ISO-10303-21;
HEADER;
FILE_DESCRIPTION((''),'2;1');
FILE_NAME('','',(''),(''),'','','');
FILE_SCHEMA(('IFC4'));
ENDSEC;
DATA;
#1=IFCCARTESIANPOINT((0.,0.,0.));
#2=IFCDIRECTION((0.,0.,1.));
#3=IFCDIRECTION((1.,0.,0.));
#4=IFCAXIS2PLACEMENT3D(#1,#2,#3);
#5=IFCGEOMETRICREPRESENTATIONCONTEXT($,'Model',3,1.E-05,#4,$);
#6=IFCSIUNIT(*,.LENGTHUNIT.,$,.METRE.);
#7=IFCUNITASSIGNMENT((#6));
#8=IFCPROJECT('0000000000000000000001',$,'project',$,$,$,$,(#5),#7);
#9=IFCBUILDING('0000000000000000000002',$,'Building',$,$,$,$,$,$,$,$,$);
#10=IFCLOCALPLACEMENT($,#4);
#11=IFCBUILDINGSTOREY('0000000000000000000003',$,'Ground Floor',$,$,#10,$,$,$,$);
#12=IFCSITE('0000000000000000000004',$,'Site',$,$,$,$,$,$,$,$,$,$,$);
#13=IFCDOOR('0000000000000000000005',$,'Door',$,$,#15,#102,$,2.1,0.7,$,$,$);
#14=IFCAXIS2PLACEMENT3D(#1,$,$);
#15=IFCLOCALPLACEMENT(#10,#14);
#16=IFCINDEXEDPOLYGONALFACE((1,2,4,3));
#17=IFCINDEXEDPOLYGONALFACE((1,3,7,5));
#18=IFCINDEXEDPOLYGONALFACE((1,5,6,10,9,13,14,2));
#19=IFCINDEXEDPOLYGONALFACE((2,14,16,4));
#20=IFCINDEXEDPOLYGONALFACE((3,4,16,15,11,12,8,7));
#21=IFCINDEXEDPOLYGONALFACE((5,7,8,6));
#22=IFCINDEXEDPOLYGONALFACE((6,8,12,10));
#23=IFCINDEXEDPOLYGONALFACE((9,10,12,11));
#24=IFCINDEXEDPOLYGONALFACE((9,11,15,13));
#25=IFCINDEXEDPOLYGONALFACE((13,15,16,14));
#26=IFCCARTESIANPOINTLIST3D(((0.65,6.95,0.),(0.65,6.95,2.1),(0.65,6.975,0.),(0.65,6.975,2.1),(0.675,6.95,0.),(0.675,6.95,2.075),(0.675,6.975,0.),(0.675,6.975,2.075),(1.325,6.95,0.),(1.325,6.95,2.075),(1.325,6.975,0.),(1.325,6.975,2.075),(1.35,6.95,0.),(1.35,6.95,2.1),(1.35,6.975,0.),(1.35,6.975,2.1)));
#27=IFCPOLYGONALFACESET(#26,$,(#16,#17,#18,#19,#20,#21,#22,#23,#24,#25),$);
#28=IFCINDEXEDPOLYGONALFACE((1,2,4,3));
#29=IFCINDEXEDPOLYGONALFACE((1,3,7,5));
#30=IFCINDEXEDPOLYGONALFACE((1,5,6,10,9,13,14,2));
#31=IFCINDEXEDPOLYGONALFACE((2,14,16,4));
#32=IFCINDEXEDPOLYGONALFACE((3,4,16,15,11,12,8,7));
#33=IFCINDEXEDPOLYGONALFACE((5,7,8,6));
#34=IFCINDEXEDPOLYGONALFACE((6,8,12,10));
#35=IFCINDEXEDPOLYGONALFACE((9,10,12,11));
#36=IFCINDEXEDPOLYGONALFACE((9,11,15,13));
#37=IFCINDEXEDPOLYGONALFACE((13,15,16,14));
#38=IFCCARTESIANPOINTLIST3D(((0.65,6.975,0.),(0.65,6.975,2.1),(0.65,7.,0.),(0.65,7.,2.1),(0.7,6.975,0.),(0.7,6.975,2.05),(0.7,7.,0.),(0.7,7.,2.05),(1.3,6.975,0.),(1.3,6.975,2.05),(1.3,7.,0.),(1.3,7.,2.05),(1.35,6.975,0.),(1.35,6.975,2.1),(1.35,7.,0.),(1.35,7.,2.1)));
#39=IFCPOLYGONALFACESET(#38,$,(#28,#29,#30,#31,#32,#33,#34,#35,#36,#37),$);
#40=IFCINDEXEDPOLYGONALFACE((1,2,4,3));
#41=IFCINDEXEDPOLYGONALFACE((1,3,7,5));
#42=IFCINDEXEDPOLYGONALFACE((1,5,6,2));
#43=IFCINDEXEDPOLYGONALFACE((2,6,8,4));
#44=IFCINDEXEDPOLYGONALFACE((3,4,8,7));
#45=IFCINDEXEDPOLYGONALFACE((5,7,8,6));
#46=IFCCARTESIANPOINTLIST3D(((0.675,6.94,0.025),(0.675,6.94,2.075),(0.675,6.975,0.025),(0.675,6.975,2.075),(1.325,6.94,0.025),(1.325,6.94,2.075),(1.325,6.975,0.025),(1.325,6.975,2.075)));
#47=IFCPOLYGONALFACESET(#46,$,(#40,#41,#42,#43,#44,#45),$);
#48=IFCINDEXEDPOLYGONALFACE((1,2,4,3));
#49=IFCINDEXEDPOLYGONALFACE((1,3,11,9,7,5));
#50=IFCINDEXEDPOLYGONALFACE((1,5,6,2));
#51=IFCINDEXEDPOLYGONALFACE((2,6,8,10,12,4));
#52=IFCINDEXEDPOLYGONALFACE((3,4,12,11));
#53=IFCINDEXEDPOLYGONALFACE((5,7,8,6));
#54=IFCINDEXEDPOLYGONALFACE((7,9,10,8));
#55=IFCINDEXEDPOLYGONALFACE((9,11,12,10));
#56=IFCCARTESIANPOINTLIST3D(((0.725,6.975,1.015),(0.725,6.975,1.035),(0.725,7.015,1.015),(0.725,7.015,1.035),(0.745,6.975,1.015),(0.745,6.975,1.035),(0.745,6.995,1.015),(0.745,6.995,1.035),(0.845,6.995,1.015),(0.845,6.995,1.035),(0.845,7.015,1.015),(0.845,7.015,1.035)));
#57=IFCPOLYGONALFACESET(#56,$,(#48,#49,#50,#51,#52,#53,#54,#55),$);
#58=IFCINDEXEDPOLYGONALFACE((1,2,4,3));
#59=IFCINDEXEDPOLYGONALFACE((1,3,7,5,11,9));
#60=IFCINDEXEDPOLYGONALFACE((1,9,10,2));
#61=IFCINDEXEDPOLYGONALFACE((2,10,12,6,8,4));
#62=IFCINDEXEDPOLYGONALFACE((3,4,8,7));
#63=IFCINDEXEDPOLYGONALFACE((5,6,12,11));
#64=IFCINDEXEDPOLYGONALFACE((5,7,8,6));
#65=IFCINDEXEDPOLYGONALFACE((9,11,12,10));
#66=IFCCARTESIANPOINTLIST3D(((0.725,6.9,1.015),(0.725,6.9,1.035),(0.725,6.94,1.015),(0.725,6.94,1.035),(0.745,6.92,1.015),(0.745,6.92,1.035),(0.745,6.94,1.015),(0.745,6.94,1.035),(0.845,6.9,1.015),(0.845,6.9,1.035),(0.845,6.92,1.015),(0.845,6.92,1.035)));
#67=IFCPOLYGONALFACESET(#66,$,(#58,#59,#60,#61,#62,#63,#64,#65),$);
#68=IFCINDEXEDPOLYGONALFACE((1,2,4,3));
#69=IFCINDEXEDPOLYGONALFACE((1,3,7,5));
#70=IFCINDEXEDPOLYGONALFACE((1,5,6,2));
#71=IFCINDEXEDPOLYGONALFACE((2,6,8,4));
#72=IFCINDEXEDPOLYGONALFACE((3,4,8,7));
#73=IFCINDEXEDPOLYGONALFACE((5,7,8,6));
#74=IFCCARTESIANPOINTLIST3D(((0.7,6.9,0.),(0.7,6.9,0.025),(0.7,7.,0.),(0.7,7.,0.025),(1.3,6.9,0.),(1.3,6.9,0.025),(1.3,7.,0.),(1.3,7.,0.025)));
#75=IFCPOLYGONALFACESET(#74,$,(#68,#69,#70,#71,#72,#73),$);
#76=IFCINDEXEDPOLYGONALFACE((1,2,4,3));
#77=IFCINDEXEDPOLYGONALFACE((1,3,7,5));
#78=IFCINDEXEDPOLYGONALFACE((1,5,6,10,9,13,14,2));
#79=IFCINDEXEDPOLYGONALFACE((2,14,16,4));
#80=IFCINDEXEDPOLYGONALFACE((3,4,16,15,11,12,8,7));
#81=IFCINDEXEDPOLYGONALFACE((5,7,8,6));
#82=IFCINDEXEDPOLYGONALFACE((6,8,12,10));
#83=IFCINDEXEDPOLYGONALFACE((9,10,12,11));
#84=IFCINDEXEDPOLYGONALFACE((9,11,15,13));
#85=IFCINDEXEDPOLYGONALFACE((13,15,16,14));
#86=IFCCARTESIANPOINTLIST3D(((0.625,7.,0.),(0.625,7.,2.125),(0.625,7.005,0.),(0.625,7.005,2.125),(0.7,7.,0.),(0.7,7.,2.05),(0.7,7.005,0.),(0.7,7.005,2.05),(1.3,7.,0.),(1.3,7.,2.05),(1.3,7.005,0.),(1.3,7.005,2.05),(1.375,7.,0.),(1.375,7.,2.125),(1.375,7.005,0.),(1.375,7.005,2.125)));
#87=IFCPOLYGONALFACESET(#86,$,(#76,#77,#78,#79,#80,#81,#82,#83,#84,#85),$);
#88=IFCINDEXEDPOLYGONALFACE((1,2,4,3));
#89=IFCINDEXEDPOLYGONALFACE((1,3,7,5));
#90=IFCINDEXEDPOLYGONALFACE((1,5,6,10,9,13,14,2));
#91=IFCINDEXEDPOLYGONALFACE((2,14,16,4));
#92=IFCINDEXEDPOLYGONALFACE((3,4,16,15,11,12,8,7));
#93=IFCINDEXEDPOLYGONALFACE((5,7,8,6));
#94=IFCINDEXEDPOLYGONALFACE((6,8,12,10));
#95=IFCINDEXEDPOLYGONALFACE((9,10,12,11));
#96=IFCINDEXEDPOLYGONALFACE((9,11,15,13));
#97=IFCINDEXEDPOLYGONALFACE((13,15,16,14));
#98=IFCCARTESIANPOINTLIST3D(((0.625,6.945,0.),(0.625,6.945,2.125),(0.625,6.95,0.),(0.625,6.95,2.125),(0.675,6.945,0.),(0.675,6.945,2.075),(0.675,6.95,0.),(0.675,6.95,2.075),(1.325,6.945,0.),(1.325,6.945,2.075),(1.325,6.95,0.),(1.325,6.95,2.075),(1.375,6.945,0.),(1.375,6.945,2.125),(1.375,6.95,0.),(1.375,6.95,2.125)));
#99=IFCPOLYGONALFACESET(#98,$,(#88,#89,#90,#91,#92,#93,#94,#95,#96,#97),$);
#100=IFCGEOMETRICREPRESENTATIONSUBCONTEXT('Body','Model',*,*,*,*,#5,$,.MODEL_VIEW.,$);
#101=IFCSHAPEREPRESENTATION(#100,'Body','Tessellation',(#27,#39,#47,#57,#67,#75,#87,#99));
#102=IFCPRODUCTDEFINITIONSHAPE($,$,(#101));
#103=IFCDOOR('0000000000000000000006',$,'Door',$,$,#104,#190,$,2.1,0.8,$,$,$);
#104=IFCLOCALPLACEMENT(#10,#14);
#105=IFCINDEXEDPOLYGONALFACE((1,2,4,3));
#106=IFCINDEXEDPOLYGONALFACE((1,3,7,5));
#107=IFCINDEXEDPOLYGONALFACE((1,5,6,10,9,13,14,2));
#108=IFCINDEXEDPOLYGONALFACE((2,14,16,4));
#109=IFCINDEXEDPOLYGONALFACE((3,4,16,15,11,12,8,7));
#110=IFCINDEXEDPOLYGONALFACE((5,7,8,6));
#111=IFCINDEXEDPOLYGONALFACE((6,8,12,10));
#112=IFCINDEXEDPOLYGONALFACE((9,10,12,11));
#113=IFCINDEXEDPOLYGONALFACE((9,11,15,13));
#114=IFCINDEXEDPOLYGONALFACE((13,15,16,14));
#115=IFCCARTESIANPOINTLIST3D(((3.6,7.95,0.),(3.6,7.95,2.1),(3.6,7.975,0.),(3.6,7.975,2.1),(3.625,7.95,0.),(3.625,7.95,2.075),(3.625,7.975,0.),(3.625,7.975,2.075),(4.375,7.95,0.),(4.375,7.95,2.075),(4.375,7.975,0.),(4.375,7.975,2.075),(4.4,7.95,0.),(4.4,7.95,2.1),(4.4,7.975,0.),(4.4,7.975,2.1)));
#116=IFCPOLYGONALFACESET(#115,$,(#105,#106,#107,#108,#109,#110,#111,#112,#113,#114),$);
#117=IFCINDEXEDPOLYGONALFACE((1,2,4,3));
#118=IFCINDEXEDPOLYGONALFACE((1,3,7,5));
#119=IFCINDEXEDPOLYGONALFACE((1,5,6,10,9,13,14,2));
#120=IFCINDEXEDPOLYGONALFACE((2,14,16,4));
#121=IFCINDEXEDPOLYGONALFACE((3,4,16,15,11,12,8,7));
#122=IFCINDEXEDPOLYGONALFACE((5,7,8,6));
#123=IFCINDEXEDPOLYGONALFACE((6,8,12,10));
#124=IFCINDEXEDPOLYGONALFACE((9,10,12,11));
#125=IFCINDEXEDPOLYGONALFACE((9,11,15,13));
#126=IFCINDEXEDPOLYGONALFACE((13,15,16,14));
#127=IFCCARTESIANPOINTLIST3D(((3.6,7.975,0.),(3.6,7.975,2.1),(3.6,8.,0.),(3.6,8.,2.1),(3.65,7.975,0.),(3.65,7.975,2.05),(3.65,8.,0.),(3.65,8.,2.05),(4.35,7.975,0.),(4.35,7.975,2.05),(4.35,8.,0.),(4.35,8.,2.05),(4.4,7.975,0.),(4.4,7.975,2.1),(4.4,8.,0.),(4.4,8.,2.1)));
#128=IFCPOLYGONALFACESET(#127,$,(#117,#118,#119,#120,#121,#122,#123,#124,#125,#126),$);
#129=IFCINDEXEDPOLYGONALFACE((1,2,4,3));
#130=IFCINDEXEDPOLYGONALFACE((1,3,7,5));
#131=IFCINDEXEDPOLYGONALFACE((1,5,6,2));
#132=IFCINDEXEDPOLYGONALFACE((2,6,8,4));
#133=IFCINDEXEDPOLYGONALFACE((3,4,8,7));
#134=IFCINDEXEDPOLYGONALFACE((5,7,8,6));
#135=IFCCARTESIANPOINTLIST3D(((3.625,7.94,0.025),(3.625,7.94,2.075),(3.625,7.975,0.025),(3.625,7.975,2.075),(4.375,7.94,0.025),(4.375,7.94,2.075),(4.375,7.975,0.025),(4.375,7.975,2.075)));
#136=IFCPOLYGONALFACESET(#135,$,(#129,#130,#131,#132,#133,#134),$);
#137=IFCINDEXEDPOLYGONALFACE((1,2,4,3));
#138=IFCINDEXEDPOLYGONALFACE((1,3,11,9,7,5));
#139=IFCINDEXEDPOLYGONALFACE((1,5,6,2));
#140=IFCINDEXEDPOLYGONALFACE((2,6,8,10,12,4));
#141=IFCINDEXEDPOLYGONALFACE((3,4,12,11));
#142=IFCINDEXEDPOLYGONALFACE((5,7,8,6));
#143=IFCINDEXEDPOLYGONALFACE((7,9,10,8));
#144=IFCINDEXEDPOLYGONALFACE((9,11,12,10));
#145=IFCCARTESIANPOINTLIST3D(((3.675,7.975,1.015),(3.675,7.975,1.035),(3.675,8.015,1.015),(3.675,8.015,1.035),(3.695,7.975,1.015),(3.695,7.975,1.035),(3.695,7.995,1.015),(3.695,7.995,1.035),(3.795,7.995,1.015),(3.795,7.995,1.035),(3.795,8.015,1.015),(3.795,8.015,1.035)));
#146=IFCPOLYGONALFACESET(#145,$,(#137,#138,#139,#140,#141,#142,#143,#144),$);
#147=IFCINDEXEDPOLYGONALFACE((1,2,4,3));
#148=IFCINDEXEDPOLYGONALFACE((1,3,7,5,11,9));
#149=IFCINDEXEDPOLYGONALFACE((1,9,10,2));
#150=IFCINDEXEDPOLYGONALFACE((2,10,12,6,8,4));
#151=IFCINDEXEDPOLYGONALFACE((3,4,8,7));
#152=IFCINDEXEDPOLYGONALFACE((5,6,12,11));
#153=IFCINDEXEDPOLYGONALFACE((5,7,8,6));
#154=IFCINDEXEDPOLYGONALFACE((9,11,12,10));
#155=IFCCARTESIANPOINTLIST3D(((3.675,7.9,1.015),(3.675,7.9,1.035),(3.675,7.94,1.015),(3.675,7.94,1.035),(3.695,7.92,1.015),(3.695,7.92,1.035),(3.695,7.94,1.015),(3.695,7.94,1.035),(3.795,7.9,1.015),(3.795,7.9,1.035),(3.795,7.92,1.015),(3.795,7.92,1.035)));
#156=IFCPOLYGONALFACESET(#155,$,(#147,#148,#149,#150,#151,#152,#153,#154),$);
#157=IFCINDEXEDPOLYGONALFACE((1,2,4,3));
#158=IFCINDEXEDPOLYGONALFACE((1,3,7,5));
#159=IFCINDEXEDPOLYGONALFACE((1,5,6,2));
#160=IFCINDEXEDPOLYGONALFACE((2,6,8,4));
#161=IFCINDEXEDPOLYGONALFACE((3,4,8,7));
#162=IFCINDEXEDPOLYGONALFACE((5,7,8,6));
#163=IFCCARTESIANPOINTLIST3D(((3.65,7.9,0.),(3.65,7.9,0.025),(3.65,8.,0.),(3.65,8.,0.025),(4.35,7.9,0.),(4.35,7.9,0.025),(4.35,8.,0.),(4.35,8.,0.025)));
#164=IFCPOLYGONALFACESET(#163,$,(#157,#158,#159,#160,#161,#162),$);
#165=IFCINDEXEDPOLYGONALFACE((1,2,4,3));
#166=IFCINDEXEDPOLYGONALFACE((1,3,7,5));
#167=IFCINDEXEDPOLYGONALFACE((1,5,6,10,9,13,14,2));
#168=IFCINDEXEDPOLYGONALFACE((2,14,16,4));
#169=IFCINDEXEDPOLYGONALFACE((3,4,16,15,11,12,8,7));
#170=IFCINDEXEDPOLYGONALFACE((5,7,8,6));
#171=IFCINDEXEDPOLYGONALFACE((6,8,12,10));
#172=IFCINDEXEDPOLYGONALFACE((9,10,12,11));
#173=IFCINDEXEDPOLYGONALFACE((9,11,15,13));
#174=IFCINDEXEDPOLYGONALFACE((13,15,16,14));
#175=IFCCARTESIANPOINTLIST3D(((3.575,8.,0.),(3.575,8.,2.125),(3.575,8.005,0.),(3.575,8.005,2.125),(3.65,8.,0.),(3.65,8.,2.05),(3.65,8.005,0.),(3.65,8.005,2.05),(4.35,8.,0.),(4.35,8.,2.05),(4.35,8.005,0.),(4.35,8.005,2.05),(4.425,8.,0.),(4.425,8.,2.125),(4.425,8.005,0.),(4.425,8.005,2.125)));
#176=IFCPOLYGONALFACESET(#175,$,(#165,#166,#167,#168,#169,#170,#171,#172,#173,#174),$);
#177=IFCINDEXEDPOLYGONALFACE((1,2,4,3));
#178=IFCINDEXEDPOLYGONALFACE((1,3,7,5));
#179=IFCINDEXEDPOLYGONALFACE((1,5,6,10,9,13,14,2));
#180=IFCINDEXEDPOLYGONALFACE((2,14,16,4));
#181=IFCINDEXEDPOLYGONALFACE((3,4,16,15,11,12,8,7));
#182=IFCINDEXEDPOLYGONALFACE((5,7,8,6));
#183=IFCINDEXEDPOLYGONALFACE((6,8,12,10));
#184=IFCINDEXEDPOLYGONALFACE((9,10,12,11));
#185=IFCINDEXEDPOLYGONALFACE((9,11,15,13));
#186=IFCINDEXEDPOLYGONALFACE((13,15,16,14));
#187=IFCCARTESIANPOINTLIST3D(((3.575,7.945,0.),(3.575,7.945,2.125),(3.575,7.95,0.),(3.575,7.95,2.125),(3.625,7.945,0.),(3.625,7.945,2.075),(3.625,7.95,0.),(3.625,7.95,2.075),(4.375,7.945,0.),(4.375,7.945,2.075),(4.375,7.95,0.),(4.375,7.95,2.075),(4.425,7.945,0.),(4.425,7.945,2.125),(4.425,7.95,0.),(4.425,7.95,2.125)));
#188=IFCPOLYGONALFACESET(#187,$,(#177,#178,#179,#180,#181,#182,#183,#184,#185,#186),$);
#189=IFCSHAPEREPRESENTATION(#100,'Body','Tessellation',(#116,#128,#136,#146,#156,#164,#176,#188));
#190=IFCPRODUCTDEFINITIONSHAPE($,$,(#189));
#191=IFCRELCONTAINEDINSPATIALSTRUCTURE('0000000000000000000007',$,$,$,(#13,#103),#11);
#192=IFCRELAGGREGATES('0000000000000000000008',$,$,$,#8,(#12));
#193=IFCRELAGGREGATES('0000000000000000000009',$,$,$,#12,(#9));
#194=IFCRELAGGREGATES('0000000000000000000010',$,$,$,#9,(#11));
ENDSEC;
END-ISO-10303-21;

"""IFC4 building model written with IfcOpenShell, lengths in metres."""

from ifc_helpers import new_model, si_unit, frame, origin_with_axes, place, context, subcontext, project, spatial, line, indexed_curve, outline, extrude, element, save


model = new_model("IFC4")

# Units and contexts
model_context = context("Model", 3, precision=1e-05, world=origin_with_axes())
body_context = subcontext(model_context, "Body", "Model", "MODEL_VIEW")
ifc_project = project(units=[si_unit("LENGTHUNIT", "METRE")], contexts=[model_context])

# Site, building, storey
site = spatial("IfcSite", under=ifc_project, Name="Site")
building = spatial("IfcBuilding", under=site, Name="Building")
storey_placement = place(None, origin_with_axes())
storey = spatial("IfcBuildingStorey", under=building, at=storey_placement, Name="Ground Floor")

# Doors
door_1_placement = place(storey_placement, frame((1.35, 7.0, 0.0), z_axis=(0.0, 0.0, 1.0), x_axis=(-1.0, 0.0, 0.0)))
element("IfcDoor", 1, at=door_1_placement, inside=storey, Name="Door", OverallHeight=2.1, OverallWidth=0.7, context=body_context, shape_type="SweptSolid", body=[
    extrude(outline(indexed_curve([(0.0, 0.0), (0.0, 2.1), (0.7, 2.1), (0.7, 0.0), (0.675, 0.0), (0.675, 2.075), (0.025, 2.075), (0.025, 0.0)], segments=[line(1, 2, 3, 4, 5, 6, 7, 8, 1)])), frame((0.0, 0.025, 0.0), z_axis=(0.0, -1.0, 0.0), x_axis=(1.0, 0.0, 0.0)), (0.0, 0.0, -1.0), 0.025),
    extrude(outline(indexed_curve([(0.0, 0.0), (0.0, 2.1), (0.7, 2.1), (0.7, 0.0), (0.65, 0.0), (0.65, 2.05), (0.05, 2.05), (0.05, 0.0)], segments=[line(1, 2, 3, 4, 5, 6, 7, 8, 1)])), frame((0.0, 0.0, 0.0), z_axis=(0.0, -1.0, 0.0), x_axis=(1.0, 0.0, 0.0)), (0.0, 0.0, -1.0), 0.025),
    extrude(outline(indexed_curve([(0.0, 0.0), (0.65, 0.0), (0.65, 0.035), (0.0, 0.035)], segments=[line(1, 2, 3, 4, 1)])), frame((0.025, 0.025, 0.025), z_axis=(0.0, 0.0, 1.0), x_axis=(1.0, 0.0, 0.0)), (0.0, 0.0, 1.0), 2.05),
    extrude(outline(indexed_curve([(0.0, 0.0), (0.0, -0.04), (-0.12, -0.04), (-0.12, -0.02), (-0.02, -0.02), (-0.02, 0.0)], segments=[line(1, 2, 3, 4, 5, 6, 1)])), frame((0.625, 0.025, 1.015), z_axis=(0.0, 0.0, 1.0), x_axis=(1.0, 0.0, 0.0)), (0.0, 0.0, 1.0), 0.02),
    extrude(outline(indexed_curve([(0.0, 0.0), (0.0, 0.04), (-0.12, 0.04), (-0.12, 0.02), (-0.02, 0.02), (-0.02, 0.0)], segments=[line(1, 2, 3, 4, 5, 6, 1)])), frame((0.625, 0.06, 1.015), z_axis=(0.0, 0.0, 1.0), x_axis=(1.0, 0.0, 0.0)), (0.0, 0.0, 1.0), 0.02),
    extrude(outline(indexed_curve([(0.0, 0.0), (0.6, 0.0), (0.6, 0.1), (0.0, 0.1)], segments=[line(1, 2, 3, 4, 1)])), frame((0.05, 0.0, 0.0), z_axis=(0.0, 0.0, 1.0), x_axis=(1.0, 0.0, 0.0)), (0.0, 0.0, 1.0), 0.025),
    extrude(outline(indexed_curve([(0.0, 0.0), (0.0, 2.125), (0.75, 2.125), (0.75, 0.0), (0.675, 0.0), (0.675, 2.05), (0.075, 2.05), (0.075, 0.0)], segments=[line(1, 2, 3, 4, 5, 6, 7, 8, 1)])), frame((-0.025, -0.005, 0.0), z_axis=(0.0, -1.0, 0.0), x_axis=(1.0, 0.0, 0.0)), (0.0, 0.0, -1.0), 0.005),
    extrude(outline(indexed_curve([(0.0, 0.0), (0.0, 2.125), (0.75, 2.125), (0.75, 0.0), (0.7, 0.0), (0.7, 2.075), (0.05, 2.075), (0.05, 0.0)], segments=[line(1, 2, 3, 4, 5, 6, 7, 8, 1)])), frame((-0.025, 0.05, 0.0), z_axis=(0.0, -1.0, 0.0), x_axis=(1.0, 0.0, 0.0)), (0.0, 0.0, -1.0), 0.005),
])
door_2_placement = place(storey_placement, frame((4.4, 8.0, 0.0), z_axis=(0.0, 0.0, 1.0), x_axis=(-1.0, 0.0, 0.0)))
element("IfcDoor", 2, at=door_2_placement, inside=storey, Name="Door", OverallHeight=2.1, OverallWidth=0.8, context=body_context, shape_type="SweptSolid", body=[
    extrude(outline(indexed_curve([(0.0, 0.0), (0.0, 2.1), (0.8, 2.1), (0.8, 0.0), (0.775, 0.0), (0.775, 2.075), (0.025, 2.075), (0.025, 0.0)], segments=[line(1, 2, 3, 4, 5, 6, 7, 8, 1)])), frame((0.0, 0.025, 0.0), z_axis=(0.0, -1.0, 0.0), x_axis=(1.0, 0.0, 0.0)), (0.0, 0.0, -1.0), 0.025),
    extrude(outline(indexed_curve([(0.0, 0.0), (0.0, 2.1), (0.8, 2.1), (0.8, 0.0), (0.75, 0.0), (0.75, 2.05), (0.05, 2.05), (0.05, 0.0)], segments=[line(1, 2, 3, 4, 5, 6, 7, 8, 1)])), frame((0.0, 0.0, 0.0), z_axis=(0.0, -1.0, 0.0), x_axis=(1.0, 0.0, 0.0)), (0.0, 0.0, -1.0), 0.025),
    extrude(outline(indexed_curve([(0.0, 0.0), (0.75, 0.0), (0.75, 0.035), (0.0, 0.035)], segments=[line(1, 2, 3, 4, 1)])), frame((0.025, 0.025, 0.025), z_axis=(0.0, 0.0, 1.0), x_axis=(1.0, 0.0, 0.0)), (0.0, 0.0, 1.0), 2.05),
    extrude(outline(indexed_curve([(0.0, 0.0), (0.0, -0.04), (-0.12, -0.04), (-0.12, -0.02), (-0.02, -0.02), (-0.02, 0.0)], segments=[line(1, 2, 3, 4, 5, 6, 1)])), frame((0.725, 0.025, 1.015), z_axis=(0.0, 0.0, 1.0), x_axis=(1.0, 0.0, 0.0)), (0.0, 0.0, 1.0), 0.02),
    extrude(outline(indexed_curve([(0.0, 0.0), (0.0, 0.04), (-0.12, 0.04), (-0.12, 0.02), (-0.02, 0.02), (-0.02, 0.0)], segments=[line(1, 2, 3, 4, 5, 6, 1)])), frame((0.725, 0.06, 1.015), z_axis=(0.0, 0.0, 1.0), x_axis=(1.0, 0.0, 0.0)), (0.0, 0.0, 1.0), 0.02),
    extrude(outline(indexed_curve([(0.0, 0.0), (0.7, 0.0), (0.7, 0.1), (0.0, 0.1)], segments=[line(1, 2, 3, 4, 1)])), frame((0.05, 0.0, 0.0), z_axis=(0.0, 0.0, 1.0), x_axis=(1.0, 0.0, 0.0)), (0.0, 0.0, 1.0), 0.025),
    extrude(outline(indexed_curve([(0.0, 0.0), (0.0, 2.125), (0.85, 2.125), (0.85, 0.0), (0.775, 0.0), (0.775, 2.05), (0.075, 2.05), (0.075, 0.0)], segments=[line(1, 2, 3, 4, 5, 6, 7, 8, 1)])), frame((-0.025, -0.005, 0.0), z_axis=(0.0, -1.0, 0.0), x_axis=(1.0, 0.0, 0.0)), (0.0, 0.0, -1.0), 0.005),
    extrude(outline(indexed_curve([(0.0, 0.0), (0.0, 2.125), (0.85, 2.125), (0.85, 0.0), (0.8, 0.0), (0.8, 2.075), (0.05, 2.075), (0.05, 0.0)], segments=[line(1, 2, 3, 4, 5, 6, 7, 8, 1)])), frame((-0.025, 0.05, 0.0), z_axis=(0.0, -1.0, 0.0), x_axis=(1.0, 0.0, 0.0)), (0.0, 0.0, -1.0), 0.005),
])

save(model, "model.ifc")
